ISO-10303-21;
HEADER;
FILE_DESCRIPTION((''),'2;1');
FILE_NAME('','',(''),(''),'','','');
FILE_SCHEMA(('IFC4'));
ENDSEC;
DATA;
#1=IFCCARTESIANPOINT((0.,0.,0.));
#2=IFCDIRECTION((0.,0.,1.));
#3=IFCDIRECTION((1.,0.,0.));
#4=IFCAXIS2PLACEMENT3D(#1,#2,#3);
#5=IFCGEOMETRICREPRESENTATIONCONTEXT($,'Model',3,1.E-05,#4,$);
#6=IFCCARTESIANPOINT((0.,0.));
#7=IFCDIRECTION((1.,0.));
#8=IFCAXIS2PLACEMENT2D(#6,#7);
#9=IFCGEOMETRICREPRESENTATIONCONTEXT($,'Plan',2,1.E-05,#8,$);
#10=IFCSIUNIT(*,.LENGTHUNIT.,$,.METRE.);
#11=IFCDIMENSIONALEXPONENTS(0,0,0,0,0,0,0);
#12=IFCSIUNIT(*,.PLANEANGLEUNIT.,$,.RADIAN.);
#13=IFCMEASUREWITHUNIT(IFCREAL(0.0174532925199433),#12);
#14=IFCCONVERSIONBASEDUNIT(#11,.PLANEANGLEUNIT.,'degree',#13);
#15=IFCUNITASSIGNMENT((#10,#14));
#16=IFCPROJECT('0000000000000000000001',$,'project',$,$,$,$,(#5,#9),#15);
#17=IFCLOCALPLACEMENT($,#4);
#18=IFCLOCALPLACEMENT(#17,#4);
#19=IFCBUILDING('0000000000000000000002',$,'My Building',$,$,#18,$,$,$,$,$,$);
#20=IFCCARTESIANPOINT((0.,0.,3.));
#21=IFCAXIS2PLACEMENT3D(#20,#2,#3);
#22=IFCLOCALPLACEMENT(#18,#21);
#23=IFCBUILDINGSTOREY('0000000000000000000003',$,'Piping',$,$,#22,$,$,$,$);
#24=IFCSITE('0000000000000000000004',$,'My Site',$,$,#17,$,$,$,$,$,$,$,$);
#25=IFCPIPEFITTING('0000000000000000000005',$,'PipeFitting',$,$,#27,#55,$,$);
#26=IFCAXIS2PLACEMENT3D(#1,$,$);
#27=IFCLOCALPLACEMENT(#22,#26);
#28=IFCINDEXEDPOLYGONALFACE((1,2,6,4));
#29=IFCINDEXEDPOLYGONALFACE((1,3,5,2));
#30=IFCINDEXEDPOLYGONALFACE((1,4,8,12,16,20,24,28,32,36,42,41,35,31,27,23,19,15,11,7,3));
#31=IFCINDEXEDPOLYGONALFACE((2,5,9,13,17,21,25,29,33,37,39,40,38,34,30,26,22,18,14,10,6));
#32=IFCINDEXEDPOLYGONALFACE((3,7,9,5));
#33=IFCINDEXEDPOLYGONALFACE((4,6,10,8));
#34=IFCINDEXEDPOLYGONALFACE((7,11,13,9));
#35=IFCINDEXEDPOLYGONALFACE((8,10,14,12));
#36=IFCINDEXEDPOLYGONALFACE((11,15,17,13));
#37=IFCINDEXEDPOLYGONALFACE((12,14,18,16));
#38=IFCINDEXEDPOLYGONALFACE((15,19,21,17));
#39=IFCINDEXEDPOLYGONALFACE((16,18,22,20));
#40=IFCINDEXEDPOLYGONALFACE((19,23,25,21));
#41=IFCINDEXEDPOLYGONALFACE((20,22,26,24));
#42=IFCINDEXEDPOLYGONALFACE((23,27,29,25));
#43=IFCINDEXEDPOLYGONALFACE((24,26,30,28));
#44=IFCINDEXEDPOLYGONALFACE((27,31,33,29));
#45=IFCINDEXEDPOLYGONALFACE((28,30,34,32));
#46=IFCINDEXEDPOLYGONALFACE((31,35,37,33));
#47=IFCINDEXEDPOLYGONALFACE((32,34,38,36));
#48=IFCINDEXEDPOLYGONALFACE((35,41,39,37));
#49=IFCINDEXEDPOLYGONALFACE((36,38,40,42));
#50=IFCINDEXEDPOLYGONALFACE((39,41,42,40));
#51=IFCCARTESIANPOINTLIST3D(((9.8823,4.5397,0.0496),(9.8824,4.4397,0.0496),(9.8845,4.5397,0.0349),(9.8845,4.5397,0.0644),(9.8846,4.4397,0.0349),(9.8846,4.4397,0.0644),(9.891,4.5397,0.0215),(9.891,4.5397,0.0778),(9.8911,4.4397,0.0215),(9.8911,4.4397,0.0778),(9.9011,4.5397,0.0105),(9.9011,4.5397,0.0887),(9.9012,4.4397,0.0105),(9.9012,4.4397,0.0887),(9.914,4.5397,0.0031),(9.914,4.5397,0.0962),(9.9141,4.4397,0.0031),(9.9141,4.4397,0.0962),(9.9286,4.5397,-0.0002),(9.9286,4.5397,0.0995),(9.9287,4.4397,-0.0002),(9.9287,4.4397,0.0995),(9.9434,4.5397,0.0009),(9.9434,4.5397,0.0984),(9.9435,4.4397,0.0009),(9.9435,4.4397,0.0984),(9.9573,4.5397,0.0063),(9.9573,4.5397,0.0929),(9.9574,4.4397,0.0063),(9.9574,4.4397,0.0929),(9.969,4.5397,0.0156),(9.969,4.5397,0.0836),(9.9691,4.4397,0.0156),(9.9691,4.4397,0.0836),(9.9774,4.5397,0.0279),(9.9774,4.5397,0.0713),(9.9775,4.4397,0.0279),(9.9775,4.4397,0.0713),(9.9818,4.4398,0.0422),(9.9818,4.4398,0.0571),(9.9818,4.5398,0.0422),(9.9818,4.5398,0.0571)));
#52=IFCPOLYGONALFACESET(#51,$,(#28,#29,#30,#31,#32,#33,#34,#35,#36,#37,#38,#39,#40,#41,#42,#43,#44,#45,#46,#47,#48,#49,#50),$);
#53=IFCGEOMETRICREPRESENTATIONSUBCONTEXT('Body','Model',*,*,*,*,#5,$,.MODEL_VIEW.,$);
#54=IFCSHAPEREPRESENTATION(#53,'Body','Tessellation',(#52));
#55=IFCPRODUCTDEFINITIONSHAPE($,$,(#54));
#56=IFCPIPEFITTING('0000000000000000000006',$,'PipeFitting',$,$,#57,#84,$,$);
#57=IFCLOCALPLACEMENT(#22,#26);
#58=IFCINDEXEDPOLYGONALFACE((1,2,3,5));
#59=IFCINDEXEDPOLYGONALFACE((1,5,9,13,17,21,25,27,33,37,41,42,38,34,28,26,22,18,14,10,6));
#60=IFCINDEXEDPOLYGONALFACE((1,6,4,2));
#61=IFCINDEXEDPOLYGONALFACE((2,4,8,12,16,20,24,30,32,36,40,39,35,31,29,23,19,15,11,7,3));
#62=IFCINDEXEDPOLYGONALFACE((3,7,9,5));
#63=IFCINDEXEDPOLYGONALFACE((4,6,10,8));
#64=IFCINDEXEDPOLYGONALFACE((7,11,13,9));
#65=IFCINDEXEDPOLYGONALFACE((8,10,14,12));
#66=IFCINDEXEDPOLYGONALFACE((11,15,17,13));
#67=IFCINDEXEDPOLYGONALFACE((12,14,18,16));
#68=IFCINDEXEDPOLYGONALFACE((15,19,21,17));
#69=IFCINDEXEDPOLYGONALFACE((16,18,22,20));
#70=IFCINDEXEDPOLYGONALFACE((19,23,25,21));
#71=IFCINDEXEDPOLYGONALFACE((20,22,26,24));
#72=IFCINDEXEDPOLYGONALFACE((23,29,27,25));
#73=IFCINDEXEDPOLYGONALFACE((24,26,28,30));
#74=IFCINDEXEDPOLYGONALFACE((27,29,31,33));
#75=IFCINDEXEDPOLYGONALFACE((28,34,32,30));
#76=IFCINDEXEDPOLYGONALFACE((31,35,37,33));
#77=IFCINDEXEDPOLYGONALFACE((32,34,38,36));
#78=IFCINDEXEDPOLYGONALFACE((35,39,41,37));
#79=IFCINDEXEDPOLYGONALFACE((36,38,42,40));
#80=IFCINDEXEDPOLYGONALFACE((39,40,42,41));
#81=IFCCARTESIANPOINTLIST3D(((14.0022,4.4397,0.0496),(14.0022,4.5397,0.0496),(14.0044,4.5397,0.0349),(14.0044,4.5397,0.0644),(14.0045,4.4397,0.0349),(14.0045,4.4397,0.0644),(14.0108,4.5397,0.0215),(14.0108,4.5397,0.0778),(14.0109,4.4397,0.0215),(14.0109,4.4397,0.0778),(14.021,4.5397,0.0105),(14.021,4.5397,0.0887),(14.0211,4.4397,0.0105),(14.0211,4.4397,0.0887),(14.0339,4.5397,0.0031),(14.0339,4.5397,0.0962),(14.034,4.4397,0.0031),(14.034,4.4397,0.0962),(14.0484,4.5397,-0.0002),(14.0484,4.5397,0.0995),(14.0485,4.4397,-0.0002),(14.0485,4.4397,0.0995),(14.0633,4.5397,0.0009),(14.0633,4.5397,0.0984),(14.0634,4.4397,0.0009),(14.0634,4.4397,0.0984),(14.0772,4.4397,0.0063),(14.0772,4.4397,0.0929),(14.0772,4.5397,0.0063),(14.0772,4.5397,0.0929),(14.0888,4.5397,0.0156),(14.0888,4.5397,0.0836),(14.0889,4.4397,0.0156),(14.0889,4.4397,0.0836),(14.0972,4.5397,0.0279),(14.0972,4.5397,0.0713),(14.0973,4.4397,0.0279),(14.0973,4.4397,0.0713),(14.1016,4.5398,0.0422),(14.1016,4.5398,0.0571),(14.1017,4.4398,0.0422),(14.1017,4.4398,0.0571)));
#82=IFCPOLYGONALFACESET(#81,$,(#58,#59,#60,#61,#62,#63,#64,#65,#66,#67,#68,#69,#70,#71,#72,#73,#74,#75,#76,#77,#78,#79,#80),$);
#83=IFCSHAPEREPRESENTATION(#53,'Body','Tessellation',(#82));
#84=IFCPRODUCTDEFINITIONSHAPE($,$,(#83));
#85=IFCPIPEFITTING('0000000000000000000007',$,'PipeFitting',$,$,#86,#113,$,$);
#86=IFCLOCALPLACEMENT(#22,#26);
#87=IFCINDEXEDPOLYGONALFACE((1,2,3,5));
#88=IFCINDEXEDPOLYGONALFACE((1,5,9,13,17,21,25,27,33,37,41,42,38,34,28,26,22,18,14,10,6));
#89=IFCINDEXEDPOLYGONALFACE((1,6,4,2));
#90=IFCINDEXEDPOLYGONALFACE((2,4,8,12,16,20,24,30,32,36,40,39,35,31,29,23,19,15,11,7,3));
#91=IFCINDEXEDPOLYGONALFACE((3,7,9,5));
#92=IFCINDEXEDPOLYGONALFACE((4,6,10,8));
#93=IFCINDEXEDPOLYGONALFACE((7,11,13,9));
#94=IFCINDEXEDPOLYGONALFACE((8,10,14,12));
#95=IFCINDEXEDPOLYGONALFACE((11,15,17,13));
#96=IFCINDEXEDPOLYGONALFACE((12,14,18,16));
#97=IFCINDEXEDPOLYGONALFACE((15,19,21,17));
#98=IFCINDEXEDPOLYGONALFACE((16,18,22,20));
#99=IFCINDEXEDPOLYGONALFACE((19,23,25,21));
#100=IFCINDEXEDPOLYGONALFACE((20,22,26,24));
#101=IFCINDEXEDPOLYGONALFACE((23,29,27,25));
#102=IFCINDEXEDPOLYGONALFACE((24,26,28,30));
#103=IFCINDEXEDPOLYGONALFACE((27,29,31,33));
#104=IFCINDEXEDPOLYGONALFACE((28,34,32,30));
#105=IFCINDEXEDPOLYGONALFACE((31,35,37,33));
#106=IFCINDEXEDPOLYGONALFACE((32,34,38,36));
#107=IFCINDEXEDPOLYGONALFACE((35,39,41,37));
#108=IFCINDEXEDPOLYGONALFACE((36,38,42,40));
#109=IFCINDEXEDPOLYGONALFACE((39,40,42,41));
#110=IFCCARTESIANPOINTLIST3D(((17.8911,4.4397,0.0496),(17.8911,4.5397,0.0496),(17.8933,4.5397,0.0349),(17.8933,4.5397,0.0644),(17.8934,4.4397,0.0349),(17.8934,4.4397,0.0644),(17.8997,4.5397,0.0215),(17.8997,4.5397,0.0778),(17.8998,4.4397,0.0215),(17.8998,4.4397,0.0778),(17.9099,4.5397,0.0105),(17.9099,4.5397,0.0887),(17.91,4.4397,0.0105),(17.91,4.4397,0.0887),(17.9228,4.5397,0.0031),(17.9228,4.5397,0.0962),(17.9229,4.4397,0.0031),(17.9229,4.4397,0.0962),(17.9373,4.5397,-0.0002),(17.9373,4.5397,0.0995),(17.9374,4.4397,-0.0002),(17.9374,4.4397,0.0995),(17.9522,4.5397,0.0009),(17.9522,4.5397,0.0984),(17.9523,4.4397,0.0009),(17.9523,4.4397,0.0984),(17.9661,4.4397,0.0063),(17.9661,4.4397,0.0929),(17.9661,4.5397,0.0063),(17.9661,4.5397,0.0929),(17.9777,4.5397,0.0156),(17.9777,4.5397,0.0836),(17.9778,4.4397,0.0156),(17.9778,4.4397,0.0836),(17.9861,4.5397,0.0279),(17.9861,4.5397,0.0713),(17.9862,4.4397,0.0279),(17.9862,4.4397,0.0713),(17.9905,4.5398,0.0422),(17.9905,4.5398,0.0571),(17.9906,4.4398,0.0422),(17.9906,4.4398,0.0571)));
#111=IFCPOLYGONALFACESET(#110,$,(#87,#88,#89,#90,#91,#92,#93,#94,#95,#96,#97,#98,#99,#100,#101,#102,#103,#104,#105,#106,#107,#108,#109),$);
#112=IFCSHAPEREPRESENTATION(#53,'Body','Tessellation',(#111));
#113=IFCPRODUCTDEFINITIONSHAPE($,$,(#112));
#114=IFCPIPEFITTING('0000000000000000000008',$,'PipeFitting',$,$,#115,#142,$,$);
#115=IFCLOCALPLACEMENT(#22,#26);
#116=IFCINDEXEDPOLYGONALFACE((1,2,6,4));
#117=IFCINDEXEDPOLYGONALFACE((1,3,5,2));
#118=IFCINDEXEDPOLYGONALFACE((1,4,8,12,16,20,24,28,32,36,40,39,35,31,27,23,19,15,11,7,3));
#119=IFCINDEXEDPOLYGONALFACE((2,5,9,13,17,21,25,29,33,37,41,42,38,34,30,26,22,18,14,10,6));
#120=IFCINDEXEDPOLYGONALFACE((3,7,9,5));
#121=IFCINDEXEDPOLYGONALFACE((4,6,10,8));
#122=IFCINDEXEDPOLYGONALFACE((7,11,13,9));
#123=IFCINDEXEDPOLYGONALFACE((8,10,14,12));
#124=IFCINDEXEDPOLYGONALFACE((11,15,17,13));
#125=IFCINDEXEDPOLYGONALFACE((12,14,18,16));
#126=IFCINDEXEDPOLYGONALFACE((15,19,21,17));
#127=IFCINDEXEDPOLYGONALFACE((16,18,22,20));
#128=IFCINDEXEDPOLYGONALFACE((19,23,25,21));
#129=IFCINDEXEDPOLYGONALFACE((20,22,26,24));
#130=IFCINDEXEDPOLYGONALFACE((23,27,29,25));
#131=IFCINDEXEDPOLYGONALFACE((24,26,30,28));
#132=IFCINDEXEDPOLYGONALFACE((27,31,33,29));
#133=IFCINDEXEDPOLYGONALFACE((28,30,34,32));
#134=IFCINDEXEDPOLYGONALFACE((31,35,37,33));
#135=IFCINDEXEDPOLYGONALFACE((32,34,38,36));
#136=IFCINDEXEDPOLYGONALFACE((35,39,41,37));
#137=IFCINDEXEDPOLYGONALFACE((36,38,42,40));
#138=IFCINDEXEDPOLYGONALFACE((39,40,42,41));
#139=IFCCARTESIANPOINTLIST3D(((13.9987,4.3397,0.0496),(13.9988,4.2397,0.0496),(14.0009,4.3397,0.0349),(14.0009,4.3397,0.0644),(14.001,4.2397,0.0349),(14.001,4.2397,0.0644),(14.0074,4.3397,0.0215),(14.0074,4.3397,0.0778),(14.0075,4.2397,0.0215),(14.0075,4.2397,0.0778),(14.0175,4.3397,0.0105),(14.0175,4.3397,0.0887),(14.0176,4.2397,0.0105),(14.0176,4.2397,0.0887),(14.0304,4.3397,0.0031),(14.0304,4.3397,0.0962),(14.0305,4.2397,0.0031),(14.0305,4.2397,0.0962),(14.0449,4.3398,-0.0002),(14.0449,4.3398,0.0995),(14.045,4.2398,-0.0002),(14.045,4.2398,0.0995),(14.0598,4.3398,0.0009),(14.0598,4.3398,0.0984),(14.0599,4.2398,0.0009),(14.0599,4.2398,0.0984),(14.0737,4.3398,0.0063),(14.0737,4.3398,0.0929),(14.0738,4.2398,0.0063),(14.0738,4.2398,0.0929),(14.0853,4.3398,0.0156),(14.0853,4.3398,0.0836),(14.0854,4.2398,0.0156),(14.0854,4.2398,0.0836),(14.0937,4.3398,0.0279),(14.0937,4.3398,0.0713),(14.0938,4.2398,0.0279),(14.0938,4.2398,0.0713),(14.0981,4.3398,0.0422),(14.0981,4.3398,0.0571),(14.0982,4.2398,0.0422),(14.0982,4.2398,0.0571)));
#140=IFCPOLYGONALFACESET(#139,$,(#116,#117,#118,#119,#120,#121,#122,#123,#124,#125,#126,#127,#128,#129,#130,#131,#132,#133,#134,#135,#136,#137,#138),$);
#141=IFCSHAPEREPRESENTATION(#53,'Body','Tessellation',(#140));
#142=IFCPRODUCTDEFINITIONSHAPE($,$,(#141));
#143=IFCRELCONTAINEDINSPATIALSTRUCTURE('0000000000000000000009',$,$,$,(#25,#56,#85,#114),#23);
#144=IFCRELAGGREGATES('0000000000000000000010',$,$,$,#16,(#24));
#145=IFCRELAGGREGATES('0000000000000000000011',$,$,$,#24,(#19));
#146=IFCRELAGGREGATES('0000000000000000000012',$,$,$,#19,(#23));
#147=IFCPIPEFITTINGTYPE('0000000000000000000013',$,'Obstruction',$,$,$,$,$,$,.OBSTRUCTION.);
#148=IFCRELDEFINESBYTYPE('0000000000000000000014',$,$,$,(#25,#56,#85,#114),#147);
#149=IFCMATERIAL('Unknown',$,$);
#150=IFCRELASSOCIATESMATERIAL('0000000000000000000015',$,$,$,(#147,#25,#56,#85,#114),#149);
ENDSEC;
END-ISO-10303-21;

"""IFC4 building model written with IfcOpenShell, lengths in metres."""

from ifc_helpers import new_model, entity, si_unit, converted_unit, frame, origin_with_axes, origin_2d_with_axis, place, context, subcontext, project, spatial, circle, extrude, material, material_profile, profile_set, profile_usage, type_object, element, save


model = new_model("IFC4")

# Units and contexts
model_context = context("Model", 3, precision=1e-05, world=origin_with_axes())
plan_context = context("Plan", 2, precision=1e-05, world=origin_2d_with_axis())
body_context = subcontext(model_context, "Body", "Model", "MODEL_VIEW")
ifc_project = project(units=[si_unit("LENGTHUNIT", "METRE"), converted_unit("PLANEANGLEUNIT", "degree", entity("IfcReal", 0.0174532925199433), si_unit("PLANEANGLEUNIT", "RADIAN"), dimensions=[0, 0, 0, 0, 0, 0, 0])], contexts=[model_context, plan_context])

# Site, building, storey
site_placement = place(None, origin_with_axes())
site = spatial("IfcSite", under=ifc_project, at=site_placement, Name="My Site")
building_placement = place(site_placement, origin_with_axes())
building = spatial("IfcBuilding", under=site, at=building_placement, Name="My Building")
storey_placement = place(building_placement, frame((0.0, 0.0, 3.0), z_axis=(0.0, 0.0, 1.0), x_axis=(1.0, 0.0, 0.0)))
storey = spatial("IfcBuildingStorey", under=building, at=storey_placement, Name="Piping")

# Shared definitions
ifc_material = material(Name="Unknown")

# Pipe fittings
ifc_material_profile_1 = material_profile(ifc_material, circle(Radius=0.05))
ifc_profile_set_1 = profile_set([ifc_material_profile_1])
ifc_profile_usage_1 = profile_usage(ifc_profile_set_1, cardinal=16)
pipe_fitting_type_1 = type_object("IfcPipeFittingType", Name="Obstruction", PredefinedType="OBSTRUCTION", material=ifc_profile_set_1)
pipe_fitting_1_placement = place(storey_placement, frame((9.9324, 4.4397, 0.0496), z_axis=(-0.000872, 1.0, 0.000001), x_axis=(-1.0, -0.000872, 0.0)))
element("IfcPipeFitting", 1, at=pipe_fitting_1_placement, inside=storey, type_object=pipe_fitting_type_1, material=ifc_profile_usage_1, Name="PipeFitting", context=body_context, shape_type="SweptSolid", body=[
    extrude(circle(Radius=0.05), origin_with_axes(), (0.0, 0.0, 1.0), 0.1),
])
ifc_profile_usage_2 = profile_usage(ifc_profile_set_1, cardinal=16)
pipe_fitting_2_placement = place(storey_placement, frame((14.0522, 4.4397, 0.0496), z_axis=(-0.000872, 1.0, 0.000001), x_axis=(-1.0, -0.000872, 0.0)))
element("IfcPipeFitting", 2, at=pipe_fitting_2_placement, inside=storey, type_object=pipe_fitting_type_1, material=ifc_profile_usage_2, Name="PipeFitting", context=body_context, shape_type="SweptSolid", body=[
    extrude(circle(Radius=0.05), origin_with_axes(), (0.0, 0.0, 1.0), 0.1),
])
ifc_profile_usage_3 = profile_usage(ifc_profile_set_1, cardinal=16)
pipe_fitting_3_placement = place(storey_placement, frame((17.9411, 4.4397, 0.0496), z_axis=(-0.000872, 1.0, 0.000001), x_axis=(-1.0, -0.000872, 0.0)))
element("IfcPipeFitting", 3, at=pipe_fitting_3_placement, inside=storey, type_object=pipe_fitting_type_1, material=ifc_profile_usage_3, Name="PipeFitting", context=body_context, shape_type="SweptSolid", body=[
    extrude(circle(Radius=0.05), origin_with_axes(), (0.0, 0.0, 1.0), 0.1),
])
ifc_profile_usage_4 = profile_usage(ifc_profile_set_1, cardinal=16)
pipe_fitting_4_placement = place(storey_placement, frame((14.0488, 4.2398, 0.0496), z_axis=(-0.000873, 1.0, 0.000001), x_axis=(-1.0, -0.000873, 0.0)))
element("IfcPipeFitting", 4, at=pipe_fitting_4_placement, inside=storey, type_object=pipe_fitting_type_1, material=ifc_profile_usage_4, Name="PipeFitting", context=body_context, shape_type="SweptSolid", body=[
    extrude(circle(Radius=0.05), origin_with_axes(), (0.0, 0.0, 1.0), 0.1),
])

save(model, "model.ifc")
